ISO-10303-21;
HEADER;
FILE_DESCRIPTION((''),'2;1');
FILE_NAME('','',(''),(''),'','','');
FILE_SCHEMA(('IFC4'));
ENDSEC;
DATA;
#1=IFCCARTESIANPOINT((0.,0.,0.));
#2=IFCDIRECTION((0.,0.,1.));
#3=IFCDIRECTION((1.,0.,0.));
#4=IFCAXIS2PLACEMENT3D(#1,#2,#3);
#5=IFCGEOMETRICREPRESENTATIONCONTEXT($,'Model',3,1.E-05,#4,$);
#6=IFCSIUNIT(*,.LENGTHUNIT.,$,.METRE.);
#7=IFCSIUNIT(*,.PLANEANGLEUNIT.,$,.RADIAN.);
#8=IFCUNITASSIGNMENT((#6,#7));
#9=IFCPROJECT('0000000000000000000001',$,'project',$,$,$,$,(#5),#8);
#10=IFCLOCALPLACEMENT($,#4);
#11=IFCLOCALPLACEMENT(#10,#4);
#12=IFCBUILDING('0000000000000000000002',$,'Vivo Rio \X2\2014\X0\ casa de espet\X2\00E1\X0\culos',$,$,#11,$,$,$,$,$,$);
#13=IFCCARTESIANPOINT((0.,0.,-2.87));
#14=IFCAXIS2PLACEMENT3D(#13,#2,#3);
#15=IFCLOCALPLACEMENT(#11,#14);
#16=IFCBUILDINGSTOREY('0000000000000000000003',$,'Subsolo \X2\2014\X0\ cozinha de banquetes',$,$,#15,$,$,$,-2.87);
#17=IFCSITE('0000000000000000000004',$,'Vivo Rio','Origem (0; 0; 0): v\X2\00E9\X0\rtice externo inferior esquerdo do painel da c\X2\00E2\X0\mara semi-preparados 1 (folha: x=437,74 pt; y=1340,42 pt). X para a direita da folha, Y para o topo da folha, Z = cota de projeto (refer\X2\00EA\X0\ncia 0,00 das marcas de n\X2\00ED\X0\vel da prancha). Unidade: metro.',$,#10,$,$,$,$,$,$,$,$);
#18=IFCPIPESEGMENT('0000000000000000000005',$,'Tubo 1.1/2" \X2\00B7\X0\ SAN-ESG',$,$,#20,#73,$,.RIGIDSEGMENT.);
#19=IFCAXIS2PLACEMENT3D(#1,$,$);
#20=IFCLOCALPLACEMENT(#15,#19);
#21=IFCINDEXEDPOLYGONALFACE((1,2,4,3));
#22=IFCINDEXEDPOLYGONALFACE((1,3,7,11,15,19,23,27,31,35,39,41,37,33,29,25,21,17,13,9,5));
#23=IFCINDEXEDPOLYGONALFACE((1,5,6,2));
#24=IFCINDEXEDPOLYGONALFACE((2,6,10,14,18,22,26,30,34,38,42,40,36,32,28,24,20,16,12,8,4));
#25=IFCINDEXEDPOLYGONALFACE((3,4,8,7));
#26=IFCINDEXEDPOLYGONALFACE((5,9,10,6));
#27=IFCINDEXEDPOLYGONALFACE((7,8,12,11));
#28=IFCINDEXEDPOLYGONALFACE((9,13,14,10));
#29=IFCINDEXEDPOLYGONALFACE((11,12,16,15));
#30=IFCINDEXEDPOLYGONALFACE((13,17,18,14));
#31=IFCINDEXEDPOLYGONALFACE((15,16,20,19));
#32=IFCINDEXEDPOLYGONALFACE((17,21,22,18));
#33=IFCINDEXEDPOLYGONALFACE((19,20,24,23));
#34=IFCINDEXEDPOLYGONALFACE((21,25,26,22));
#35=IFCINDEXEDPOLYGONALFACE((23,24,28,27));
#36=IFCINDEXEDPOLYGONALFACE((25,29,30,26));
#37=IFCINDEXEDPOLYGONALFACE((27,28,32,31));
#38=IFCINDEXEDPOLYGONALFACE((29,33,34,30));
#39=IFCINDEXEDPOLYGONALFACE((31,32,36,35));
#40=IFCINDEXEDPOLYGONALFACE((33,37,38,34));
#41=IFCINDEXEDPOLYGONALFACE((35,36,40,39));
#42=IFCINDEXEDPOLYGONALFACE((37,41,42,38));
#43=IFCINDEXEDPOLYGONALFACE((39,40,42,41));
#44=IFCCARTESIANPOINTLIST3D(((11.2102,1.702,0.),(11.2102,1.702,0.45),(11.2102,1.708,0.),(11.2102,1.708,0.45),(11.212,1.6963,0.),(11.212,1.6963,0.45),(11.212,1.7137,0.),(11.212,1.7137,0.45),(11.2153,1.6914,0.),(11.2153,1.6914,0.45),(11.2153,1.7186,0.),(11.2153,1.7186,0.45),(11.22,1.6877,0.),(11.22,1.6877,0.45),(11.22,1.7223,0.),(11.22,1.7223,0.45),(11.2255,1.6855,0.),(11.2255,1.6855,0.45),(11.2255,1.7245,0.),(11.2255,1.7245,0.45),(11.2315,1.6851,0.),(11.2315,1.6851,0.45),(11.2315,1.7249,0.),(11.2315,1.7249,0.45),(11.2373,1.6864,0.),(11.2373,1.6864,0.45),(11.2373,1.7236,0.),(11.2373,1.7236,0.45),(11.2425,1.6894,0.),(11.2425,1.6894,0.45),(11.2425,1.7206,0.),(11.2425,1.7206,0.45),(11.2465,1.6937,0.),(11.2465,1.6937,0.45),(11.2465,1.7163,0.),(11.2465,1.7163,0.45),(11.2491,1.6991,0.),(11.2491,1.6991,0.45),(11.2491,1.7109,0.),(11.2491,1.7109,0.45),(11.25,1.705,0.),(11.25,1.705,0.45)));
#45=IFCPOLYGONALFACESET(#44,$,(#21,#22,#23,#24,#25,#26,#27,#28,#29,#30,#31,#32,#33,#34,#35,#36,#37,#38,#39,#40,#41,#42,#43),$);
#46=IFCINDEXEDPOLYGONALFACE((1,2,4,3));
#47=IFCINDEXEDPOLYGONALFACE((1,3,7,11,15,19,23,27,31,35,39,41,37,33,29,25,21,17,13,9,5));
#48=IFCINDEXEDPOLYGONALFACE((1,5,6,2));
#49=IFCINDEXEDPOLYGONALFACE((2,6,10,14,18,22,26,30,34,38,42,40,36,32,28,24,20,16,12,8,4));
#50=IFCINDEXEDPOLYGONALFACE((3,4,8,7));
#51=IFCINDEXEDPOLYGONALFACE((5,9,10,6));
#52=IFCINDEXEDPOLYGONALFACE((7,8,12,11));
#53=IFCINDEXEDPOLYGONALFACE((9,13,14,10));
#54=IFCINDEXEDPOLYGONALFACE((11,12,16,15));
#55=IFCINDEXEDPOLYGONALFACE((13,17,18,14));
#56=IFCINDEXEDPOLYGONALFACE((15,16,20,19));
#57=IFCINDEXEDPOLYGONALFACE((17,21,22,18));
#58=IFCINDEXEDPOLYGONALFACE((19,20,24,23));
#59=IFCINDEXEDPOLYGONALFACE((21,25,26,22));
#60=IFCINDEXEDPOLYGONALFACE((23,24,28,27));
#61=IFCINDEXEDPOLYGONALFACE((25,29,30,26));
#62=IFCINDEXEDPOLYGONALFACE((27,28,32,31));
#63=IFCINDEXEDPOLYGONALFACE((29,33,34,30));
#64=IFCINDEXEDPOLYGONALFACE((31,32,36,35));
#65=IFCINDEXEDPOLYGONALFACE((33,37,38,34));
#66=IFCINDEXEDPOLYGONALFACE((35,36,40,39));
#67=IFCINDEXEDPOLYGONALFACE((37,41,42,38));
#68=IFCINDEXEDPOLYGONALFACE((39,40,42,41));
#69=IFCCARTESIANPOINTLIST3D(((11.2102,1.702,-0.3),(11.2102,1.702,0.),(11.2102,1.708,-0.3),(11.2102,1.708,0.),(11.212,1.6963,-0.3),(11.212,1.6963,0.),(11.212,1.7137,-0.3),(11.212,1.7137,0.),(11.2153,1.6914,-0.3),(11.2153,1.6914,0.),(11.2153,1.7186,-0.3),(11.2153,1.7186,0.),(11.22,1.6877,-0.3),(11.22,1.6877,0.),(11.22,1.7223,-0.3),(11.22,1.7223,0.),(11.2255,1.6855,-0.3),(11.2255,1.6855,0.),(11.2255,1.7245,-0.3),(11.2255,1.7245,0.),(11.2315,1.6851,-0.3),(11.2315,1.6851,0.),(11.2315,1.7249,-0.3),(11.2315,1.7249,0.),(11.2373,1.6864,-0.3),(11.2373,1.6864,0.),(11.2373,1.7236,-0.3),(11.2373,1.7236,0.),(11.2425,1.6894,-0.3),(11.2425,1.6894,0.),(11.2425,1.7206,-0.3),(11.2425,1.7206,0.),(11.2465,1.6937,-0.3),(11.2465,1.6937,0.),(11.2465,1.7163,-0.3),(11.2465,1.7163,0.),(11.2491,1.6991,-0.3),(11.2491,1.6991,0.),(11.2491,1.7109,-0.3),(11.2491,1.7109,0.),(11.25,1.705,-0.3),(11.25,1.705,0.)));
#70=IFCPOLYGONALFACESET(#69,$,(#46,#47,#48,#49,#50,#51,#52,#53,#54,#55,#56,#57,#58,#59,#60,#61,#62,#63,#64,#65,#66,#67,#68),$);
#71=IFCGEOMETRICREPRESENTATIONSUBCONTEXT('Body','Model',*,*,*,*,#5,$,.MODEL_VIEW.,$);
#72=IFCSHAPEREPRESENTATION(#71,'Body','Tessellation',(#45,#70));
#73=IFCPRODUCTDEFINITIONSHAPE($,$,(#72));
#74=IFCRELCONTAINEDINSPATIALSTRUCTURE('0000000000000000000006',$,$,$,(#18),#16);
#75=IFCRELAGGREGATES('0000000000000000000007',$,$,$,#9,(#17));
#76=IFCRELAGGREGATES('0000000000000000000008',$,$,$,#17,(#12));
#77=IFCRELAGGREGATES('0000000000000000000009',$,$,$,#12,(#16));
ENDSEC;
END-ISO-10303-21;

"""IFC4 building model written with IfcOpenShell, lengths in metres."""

from ifc_helpers import new_model, si_unit, frame, origin_with_axes, origin_2d, place, context, subcontext, project, spatial, circle, extrude, element, save


model = new_model("IFC4")

# Units and contexts
model_context = context("Model", 3, precision=1e-05, world=origin_with_axes())
body_context = subcontext(model_context, "Body", "Model", "MODEL_VIEW")
ifc_project = project(units=[si_unit("LENGTHUNIT", "METRE"), si_unit("PLANEANGLEUNIT", "RADIAN")], contexts=[model_context])

# Site, building, storey
site_placement = place(None, origin_with_axes())
site = spatial("IfcSite", under=ifc_project, at=site_placement, Name="Vivo Rio", Description="Origem (0; 0; 0): vértice externo inferior esquerdo do painel da câmara semi-preparados 1 (folha: x=437,74 pt; y=1340,42 pt). X para a direita da folha, Y para o topo da folha, Z = cota de projeto (referência 0,00 das marcas de nível da prancha). Unidade: metro.")
building_placement = place(site_placement, origin_with_axes())
building = spatial("IfcBuilding", under=site, at=building_placement, Name="Vivo Rio — casa de espetáculos")
storey_placement = place(building_placement, frame((0.0, 0.0, -2.87), z_axis=(0.0, 0.0, 1.0), x_axis=(1.0, 0.0, 0.0)))
storey = spatial("IfcBuildingStorey", under=building, at=storey_placement, Name="Subsolo — cozinha de banquetes", Elevation=-2.87)

# Pipe segment
pipe_segment_1_placement = place(storey_placement, origin_with_axes())
element("IfcPipeSegment", 1, at=pipe_segment_1_placement, inside=storey, Name="Tubo 1.1/2\" · SAN-ESG", PredefinedType="RIGIDSEGMENT", context=body_context, shape_type="SweptSolid", body=[
    extrude(circle(Radius=0.02, at=origin_2d()), frame((11.23, 1.705, 0.45), z_axis=(0.0, 0.0, -1.0), x_axis=(1.0, 0.0, 0.0)), (0.0, 0.0, 1.0), 0.45),
    extrude(circle(Radius=0.02, at=origin_2d()), frame((11.23, 1.705, 0.0), z_axis=(0.0, 0.0, -1.0), x_axis=(1.0, 0.0, 0.0)), (0.0, 0.0, 1.0), 0.3),
])

save(model, "model.ifc")
